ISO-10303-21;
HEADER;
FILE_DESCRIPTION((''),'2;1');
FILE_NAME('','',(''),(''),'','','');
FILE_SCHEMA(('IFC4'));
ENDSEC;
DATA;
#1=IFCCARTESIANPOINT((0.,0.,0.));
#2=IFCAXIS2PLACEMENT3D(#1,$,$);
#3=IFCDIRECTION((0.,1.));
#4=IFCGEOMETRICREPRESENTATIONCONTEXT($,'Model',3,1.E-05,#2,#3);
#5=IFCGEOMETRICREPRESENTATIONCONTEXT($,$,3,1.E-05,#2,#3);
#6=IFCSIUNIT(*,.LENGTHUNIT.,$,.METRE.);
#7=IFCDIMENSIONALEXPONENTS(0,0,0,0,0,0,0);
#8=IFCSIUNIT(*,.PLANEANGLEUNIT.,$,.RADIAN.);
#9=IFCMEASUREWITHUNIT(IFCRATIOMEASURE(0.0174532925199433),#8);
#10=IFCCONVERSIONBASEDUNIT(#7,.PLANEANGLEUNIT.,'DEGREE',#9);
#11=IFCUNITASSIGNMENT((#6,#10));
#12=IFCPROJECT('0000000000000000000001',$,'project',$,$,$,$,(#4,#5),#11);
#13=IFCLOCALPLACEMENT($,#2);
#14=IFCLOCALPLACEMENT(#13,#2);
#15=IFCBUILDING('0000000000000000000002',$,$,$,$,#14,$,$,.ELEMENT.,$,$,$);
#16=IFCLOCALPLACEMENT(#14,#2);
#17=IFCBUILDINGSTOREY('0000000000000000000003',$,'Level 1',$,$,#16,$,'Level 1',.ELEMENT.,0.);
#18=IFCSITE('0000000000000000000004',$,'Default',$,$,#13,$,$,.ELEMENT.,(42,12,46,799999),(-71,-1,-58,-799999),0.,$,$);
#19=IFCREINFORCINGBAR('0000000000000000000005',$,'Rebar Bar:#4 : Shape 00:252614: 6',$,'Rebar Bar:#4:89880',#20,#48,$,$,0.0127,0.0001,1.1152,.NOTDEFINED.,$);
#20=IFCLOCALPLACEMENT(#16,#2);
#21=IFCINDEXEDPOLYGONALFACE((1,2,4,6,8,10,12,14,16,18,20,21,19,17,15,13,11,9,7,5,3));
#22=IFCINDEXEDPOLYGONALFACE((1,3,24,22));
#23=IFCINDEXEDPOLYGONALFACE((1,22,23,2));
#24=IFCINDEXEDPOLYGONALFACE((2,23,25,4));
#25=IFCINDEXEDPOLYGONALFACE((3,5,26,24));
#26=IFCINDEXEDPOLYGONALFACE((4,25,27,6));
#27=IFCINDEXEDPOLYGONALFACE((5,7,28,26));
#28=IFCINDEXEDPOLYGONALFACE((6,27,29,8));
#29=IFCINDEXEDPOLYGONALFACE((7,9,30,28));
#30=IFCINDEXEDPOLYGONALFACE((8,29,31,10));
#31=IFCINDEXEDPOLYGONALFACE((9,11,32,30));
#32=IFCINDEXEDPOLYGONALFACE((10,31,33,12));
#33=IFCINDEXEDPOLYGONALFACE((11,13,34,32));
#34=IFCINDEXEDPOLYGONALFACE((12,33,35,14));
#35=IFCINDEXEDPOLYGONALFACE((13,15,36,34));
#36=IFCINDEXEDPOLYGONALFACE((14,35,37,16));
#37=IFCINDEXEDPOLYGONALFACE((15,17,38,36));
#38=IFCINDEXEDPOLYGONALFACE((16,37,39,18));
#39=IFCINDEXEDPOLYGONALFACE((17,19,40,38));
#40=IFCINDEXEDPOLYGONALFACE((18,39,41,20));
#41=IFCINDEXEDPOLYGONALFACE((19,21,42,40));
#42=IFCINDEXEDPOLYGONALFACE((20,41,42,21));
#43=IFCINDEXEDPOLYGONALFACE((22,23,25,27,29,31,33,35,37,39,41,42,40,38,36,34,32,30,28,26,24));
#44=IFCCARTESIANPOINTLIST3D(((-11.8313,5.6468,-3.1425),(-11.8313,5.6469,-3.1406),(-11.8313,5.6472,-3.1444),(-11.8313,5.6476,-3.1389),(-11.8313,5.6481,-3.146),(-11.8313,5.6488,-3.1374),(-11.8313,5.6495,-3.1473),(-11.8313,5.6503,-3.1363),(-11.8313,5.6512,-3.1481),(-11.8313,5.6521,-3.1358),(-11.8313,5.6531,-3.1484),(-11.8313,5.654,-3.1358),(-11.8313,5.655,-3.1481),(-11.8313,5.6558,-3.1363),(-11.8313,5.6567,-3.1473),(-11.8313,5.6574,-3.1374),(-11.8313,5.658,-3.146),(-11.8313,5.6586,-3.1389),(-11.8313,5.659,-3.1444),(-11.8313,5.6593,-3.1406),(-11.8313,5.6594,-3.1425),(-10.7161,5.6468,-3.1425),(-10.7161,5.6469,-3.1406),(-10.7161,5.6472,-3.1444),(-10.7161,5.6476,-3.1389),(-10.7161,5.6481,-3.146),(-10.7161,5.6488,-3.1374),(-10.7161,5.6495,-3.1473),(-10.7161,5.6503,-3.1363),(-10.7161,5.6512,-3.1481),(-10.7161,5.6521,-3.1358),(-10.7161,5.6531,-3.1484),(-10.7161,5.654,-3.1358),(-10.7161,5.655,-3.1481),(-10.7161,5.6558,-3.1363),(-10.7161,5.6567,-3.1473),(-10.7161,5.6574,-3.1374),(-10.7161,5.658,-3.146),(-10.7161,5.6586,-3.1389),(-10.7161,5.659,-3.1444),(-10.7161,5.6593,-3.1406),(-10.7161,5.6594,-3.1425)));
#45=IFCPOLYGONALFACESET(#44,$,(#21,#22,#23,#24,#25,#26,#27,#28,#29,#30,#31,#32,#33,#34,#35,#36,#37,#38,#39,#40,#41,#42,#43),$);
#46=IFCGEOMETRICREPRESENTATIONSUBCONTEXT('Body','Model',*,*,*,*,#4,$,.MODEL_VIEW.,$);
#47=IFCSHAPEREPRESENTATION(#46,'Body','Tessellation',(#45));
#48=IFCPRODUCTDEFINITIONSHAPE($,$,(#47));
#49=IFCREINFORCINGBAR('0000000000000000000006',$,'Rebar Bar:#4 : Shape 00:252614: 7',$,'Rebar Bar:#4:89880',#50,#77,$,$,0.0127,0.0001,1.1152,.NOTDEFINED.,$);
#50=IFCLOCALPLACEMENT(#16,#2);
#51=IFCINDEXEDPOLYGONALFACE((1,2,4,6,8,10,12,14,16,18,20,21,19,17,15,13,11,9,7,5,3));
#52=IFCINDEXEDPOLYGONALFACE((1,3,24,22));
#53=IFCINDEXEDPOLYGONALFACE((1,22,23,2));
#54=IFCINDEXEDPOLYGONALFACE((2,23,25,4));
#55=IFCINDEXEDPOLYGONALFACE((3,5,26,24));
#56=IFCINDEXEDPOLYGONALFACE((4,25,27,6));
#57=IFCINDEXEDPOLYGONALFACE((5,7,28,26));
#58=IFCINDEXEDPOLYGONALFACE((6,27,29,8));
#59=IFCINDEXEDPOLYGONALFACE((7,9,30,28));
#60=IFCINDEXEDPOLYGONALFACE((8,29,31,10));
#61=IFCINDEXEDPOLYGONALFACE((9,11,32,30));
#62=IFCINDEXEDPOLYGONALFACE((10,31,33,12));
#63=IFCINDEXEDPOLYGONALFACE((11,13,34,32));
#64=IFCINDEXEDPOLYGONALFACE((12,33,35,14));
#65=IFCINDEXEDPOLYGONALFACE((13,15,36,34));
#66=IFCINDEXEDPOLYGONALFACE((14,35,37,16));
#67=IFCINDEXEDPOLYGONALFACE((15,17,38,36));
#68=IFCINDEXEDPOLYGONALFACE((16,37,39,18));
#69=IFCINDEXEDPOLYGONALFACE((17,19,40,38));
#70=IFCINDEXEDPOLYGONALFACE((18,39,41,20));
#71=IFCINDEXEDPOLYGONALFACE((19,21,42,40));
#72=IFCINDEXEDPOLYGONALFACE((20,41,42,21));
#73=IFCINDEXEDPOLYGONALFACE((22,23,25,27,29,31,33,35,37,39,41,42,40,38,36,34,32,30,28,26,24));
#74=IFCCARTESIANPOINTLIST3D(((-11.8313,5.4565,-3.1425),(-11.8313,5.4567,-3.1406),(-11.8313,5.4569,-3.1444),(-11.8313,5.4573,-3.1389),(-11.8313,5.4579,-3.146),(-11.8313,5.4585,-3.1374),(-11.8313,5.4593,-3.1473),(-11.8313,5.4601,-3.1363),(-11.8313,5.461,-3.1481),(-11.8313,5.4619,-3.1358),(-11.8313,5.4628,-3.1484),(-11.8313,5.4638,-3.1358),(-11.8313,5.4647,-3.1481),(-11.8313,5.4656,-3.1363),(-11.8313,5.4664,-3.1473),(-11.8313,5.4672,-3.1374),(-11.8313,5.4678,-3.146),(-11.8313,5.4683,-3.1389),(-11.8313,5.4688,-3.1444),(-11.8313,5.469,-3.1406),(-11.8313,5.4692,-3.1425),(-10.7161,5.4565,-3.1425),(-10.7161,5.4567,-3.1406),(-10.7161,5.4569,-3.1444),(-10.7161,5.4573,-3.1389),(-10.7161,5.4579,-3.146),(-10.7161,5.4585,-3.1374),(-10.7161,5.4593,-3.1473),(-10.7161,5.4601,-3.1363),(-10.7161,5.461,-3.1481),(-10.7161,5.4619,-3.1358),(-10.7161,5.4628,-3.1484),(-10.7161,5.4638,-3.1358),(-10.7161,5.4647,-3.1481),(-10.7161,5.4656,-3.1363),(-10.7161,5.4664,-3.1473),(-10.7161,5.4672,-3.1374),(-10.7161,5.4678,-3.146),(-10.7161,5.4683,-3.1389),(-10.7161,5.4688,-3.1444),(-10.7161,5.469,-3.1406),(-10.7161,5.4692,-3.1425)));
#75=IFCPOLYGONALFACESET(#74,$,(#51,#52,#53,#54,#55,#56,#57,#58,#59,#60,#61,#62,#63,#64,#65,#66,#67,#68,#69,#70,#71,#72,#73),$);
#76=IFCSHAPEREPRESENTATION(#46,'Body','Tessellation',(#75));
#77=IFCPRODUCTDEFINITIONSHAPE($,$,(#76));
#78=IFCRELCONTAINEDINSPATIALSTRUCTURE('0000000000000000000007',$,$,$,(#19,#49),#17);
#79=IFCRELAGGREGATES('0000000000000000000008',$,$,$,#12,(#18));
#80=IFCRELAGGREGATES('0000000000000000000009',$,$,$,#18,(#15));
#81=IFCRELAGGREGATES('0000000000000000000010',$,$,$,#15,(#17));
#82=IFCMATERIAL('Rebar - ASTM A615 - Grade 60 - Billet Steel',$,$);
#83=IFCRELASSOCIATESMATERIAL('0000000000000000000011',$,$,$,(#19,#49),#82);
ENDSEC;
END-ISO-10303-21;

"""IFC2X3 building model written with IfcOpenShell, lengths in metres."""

from ifc_helpers import new_model, entity, si_unit, converted_unit, direction, origin, place, context, subcontext, project, spatial, material, element, save


model = new_model("IFC2X3")

# Units and contexts
model_context = context("Model", 3, precision=1e-05, world=origin(), true_north=direction((0.0, 1.0)))
context_of_model = context(None, 3, precision=1e-05, world=origin(), true_north=direction((0.0, 1.0)))
body_context = subcontext(model_context, "Body", "Model", "MODEL_VIEW")
ifc_project = project(units=[si_unit("LENGTHUNIT", "METRE"), converted_unit("PLANEANGLEUNIT", "DEGREE", entity("IfcRatioMeasure", 0.0174532925199433), si_unit("PLANEANGLEUNIT", "RADIAN"), dimensions=[0, 0, 0, 0, 0, 0, 0])], contexts=[model_context, context_of_model])

# Site, building, storey
site_placement = place(None, origin())
site = spatial("IfcSite", under=ifc_project, at=site_placement, Name="Default", CompositionType="ELEMENT", RefLatitude=(42, 12, 46, 799999), RefLongitude=(-71, -1, -58, -799999), RefElevation=0.0)
building_placement = place(site_placement, origin())
building = spatial("IfcBuilding", under=site, at=building_placement, CompositionType="ELEMENT")
storey_placement = place(building_placement, origin())
storey = spatial("IfcBuildingStorey", under=building, at=storey_placement, Name="Level 1", LongName="Level 1", CompositionType="ELEMENT", Elevation=0.0)

# Reinforcing bars
ifc_material_1 = material(Name="Rebar - ASTM A615 - Grade 60 - Billet Steel")
reinforcing_bar_1_placement = place(storey_placement, origin())
element("IfcReinforcingBar", 1, at=reinforcing_bar_1_placement, inside=storey, material=ifc_material_1, Name="Rebar Bar:#4 : Shape 00:252614: 6", ObjectType="Rebar Bar:#4:89880", BarLength=1.1152, BarRole="NOTDEFINED", CrossSectionArea=0.0001, NominalDiameter=0.0127, context=body_context, shape_type="AdvancedSweptSolid", body=[
    entity("IfcSweptDiskSolid", entity("IfcCompositeCurve", [entity("IfcCompositeCurveSegment", "CONTINUOUS", True, entity("IfcPolyline", [entity("IfcCartesianPoint", [-10.7161, 5.6531, -3.142]), entity("IfcCartesianPoint", [-11.8313, 5.6531, -3.142])]))], False), 0.0063, None, 0.0, 1.0),
])
reinforcing_bar_2_placement = place(storey_placement, origin())
element("IfcReinforcingBar", 2, at=reinforcing_bar_2_placement, inside=storey, material=ifc_material_1, Name="Rebar Bar:#4 : Shape 00:252614: 7", ObjectType="Rebar Bar:#4:89880", BarLength=1.1152, BarRole="NOTDEFINED", CrossSectionArea=0.0001, NominalDiameter=0.0127, context=body_context, shape_type="AdvancedSweptSolid", body=[
    entity("IfcSweptDiskSolid", entity("IfcCompositeCurve", [entity("IfcCompositeCurveSegment", "CONTINUOUS", True, entity("IfcPolyline", [entity("IfcCartesianPoint", [-10.7161, 5.4628, -3.142]), entity("IfcCartesianPoint", [-11.8313, 5.4628, -3.142])]))], False), 0.0063, None, 0.0, 1.0),
])

save(model, "model.ifc")
